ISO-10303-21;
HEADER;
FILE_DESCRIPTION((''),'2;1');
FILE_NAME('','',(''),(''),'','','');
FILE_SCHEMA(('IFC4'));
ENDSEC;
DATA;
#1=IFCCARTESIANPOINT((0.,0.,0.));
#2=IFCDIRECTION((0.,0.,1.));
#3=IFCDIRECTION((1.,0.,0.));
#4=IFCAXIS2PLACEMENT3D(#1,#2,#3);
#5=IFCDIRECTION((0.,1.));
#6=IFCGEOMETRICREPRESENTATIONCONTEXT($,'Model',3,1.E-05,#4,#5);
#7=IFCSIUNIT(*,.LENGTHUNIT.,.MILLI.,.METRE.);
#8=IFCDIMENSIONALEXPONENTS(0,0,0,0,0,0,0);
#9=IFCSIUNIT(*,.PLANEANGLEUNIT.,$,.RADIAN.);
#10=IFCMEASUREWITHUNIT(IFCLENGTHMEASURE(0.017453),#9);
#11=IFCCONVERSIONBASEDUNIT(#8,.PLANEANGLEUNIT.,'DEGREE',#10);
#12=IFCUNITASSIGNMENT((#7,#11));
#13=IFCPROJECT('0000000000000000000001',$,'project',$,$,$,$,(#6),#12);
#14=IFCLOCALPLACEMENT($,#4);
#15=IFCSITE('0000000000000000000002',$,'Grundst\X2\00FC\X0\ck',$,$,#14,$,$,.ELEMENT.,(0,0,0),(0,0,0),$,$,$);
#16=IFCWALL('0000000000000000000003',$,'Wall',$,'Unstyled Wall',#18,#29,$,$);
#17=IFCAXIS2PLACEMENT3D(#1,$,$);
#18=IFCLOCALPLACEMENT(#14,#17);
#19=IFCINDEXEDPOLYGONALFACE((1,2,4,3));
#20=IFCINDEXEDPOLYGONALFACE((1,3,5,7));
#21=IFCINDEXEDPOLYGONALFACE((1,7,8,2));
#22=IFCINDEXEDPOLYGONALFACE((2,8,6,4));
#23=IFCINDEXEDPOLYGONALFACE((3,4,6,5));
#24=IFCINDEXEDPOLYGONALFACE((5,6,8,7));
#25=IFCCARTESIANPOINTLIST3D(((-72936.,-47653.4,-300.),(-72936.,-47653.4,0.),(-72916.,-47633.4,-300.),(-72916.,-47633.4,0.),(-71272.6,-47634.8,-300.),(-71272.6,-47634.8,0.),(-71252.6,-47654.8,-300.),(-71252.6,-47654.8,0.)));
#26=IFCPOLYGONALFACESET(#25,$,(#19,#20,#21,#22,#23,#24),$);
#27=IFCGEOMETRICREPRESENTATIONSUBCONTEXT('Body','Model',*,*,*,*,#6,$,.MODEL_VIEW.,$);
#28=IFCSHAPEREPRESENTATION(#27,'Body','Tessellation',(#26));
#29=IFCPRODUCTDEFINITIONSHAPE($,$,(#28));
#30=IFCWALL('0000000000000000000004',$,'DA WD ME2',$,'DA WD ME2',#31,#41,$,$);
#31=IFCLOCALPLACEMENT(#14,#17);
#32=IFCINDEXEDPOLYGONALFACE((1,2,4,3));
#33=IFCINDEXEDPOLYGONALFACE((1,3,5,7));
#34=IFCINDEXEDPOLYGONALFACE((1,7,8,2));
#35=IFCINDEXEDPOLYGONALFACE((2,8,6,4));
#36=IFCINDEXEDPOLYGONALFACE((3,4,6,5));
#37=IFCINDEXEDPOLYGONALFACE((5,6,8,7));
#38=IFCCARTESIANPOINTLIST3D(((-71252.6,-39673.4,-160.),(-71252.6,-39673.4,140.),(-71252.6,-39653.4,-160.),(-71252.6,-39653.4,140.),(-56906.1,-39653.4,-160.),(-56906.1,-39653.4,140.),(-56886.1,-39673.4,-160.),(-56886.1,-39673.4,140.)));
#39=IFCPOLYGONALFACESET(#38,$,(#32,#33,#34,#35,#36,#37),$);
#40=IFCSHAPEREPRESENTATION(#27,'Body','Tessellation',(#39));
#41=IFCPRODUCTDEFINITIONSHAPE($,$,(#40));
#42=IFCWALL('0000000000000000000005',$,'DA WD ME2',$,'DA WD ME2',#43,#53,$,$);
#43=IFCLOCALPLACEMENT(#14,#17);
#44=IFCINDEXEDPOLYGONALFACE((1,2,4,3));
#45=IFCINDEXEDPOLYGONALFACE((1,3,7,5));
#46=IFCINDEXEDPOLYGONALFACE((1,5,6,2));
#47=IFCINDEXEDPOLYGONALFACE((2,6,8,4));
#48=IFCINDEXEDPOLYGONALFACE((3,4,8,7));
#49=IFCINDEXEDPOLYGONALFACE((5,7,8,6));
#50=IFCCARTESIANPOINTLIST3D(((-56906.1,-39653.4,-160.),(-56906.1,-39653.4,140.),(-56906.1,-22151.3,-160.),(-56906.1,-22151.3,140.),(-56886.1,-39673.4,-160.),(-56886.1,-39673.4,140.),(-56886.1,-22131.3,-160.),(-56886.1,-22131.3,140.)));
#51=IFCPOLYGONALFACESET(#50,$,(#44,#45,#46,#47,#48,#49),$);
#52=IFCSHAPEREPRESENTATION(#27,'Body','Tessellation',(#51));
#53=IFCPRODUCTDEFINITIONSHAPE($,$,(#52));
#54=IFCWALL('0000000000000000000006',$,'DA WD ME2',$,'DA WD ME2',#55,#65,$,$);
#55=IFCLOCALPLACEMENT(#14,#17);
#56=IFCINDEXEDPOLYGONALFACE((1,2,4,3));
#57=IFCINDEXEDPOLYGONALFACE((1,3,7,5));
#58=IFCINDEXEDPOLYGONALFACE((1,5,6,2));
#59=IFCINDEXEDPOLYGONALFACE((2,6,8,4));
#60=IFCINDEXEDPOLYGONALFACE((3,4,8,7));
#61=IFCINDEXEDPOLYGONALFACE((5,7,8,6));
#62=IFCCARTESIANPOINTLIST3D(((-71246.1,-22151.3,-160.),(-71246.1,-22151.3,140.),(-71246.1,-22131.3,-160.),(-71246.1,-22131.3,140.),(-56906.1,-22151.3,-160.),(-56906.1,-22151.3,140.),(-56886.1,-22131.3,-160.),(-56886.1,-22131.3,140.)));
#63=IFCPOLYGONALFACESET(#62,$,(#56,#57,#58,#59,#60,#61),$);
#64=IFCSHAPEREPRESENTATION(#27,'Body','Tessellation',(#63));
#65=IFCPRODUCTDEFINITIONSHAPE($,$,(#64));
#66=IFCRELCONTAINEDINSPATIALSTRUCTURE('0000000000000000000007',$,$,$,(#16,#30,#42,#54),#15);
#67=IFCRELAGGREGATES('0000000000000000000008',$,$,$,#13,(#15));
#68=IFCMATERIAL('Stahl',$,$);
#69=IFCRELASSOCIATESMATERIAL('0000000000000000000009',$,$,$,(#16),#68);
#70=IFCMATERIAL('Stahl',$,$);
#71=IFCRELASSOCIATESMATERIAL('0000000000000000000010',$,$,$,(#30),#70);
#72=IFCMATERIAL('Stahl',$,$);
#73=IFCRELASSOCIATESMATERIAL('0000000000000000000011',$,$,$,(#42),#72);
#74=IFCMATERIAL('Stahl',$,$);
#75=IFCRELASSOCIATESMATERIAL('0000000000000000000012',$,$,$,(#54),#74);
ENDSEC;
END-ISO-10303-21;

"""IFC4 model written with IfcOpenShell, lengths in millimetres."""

from ifc_helpers import new_model, entity, si_unit, converted_unit, direction, frame, origin_with_axes, place, context, subcontext, project, spatial, line, indexed_curve, outline, extrude, material, element, save


model = new_model("IFC4")

# Units and contexts
model_context = context("Model", 3, precision=1e-05, world=origin_with_axes(), true_north=direction((0.0, 1.0)))
body_context = subcontext(model_context, "Body", "Model", "MODEL_VIEW")
ifc_project = project(units=[si_unit("LENGTHUNIT", "METRE", prefix="MILLI"), converted_unit("PLANEANGLEUNIT", "DEGREE", entity("IfcLengthMeasure", 0.017453), si_unit("PLANEANGLEUNIT", "RADIAN"), dimensions=[0, 0, 0, 0, 0, 0, 0])], contexts=[model_context])

# Site
site_placement = place(None, origin_with_axes())
site = spatial("IfcSite", under=ifc_project, at=site_placement, Name="Grundstück", CompositionType="ELEMENT", RefLatitude=(0, 0, 0), RefLongitude=(0, 0, 0))

# Walls
ifc_material_1 = material(Name="Stahl")
wall_1_placement = place(site_placement, frame((-72926.0, -47643.4, -300.0), z_axis=(0.0, 0.0, 1.0), x_axis=(1.0, -0.00083, 0.0)))
element("IfcWall", 1, at=wall_1_placement, inside=site, material=ifc_material_1, Name="Wall", ObjectType="Unstyled Wall", context=body_context, shape_type="SweptSolid", body=[
    extrude(outline(indexed_curve([(-10.0, -10.0), (10.0, 10.0), (1653.4, 10.0), (1673.4, -10.0)], segments=[line(1, 2), line(2, 3), line(3, 4), line(4, 1)])), origin_with_axes(), (0.0, 0.0, 1.0), 300.0),
])
ifc_material_2 = material(Name="Stahl")
wall_2_placement = place(site_placement, frame((-71252.6, -39663.4, -160.0), z_axis=(0.0, 0.0, 1.0), x_axis=(1.0, 0.0, 0.0)))
element("IfcWall", 2, at=wall_2_placement, inside=site, material=ifc_material_2, Name="DA WD ME2", ObjectType="DA WD ME2", context=body_context, shape_type="SweptSolid", body=[
    extrude(outline(indexed_curve([(0.0, -10.0), (0.0, 10.0), (14346.6, 10.0), (14366.6, -10.0)], segments=[line(1, 2), line(2, 3), line(3, 4), line(4, 1)])), origin_with_axes(), (0.0, 0.0, 1.0), 300.0),
])
ifc_material_3 = material(Name="Stahl")
wall_3_placement = place(site_placement, frame((-56896.1, -39663.4, -160.0), z_axis=(0.0, 0.0, 1.0), x_axis=(0.0, 1.0, 0.0)))
element("IfcWall", 3, at=wall_3_placement, inside=site, material=ifc_material_3, Name="DA WD ME2", ObjectType="DA WD ME2", context=body_context, shape_type="SweptSolid", body=[
    extrude(outline(indexed_curve([(10.0, 10.0), (-10.0, -10.0), (17532.1, -10.0), (17512.1, 10.0)], segments=[line(1, 2), line(2, 3), line(3, 4), line(4, 1)])), origin_with_axes(), (0.0, 0.0, 1.0), 300.0),
])
ifc_material_4 = material(Name="Stahl")
wall_4_placement = place(site_placement, frame((-56896.1, -22141.3, -160.0), z_axis=(0.0, 0.0, 1.0), x_axis=(-1.0, 0.0, 0.0)))
element("IfcWall", 4, at=wall_4_placement, inside=site, material=ifc_material_4, Name="DA WD ME2", ObjectType="DA WD ME2", context=body_context, shape_type="SweptSolid", body=[
    extrude(outline(indexed_curve([(-10.0, -10.0), (10.0, 10.0), (14350.0, 10.0), (14350.0, -10.0)], segments=[line(1, 2), line(2, 3), line(3, 4), line(4, 1)])), origin_with_axes(), (0.0, 0.0, 1.0), 300.0),
])

save(model, "model.ifc")
